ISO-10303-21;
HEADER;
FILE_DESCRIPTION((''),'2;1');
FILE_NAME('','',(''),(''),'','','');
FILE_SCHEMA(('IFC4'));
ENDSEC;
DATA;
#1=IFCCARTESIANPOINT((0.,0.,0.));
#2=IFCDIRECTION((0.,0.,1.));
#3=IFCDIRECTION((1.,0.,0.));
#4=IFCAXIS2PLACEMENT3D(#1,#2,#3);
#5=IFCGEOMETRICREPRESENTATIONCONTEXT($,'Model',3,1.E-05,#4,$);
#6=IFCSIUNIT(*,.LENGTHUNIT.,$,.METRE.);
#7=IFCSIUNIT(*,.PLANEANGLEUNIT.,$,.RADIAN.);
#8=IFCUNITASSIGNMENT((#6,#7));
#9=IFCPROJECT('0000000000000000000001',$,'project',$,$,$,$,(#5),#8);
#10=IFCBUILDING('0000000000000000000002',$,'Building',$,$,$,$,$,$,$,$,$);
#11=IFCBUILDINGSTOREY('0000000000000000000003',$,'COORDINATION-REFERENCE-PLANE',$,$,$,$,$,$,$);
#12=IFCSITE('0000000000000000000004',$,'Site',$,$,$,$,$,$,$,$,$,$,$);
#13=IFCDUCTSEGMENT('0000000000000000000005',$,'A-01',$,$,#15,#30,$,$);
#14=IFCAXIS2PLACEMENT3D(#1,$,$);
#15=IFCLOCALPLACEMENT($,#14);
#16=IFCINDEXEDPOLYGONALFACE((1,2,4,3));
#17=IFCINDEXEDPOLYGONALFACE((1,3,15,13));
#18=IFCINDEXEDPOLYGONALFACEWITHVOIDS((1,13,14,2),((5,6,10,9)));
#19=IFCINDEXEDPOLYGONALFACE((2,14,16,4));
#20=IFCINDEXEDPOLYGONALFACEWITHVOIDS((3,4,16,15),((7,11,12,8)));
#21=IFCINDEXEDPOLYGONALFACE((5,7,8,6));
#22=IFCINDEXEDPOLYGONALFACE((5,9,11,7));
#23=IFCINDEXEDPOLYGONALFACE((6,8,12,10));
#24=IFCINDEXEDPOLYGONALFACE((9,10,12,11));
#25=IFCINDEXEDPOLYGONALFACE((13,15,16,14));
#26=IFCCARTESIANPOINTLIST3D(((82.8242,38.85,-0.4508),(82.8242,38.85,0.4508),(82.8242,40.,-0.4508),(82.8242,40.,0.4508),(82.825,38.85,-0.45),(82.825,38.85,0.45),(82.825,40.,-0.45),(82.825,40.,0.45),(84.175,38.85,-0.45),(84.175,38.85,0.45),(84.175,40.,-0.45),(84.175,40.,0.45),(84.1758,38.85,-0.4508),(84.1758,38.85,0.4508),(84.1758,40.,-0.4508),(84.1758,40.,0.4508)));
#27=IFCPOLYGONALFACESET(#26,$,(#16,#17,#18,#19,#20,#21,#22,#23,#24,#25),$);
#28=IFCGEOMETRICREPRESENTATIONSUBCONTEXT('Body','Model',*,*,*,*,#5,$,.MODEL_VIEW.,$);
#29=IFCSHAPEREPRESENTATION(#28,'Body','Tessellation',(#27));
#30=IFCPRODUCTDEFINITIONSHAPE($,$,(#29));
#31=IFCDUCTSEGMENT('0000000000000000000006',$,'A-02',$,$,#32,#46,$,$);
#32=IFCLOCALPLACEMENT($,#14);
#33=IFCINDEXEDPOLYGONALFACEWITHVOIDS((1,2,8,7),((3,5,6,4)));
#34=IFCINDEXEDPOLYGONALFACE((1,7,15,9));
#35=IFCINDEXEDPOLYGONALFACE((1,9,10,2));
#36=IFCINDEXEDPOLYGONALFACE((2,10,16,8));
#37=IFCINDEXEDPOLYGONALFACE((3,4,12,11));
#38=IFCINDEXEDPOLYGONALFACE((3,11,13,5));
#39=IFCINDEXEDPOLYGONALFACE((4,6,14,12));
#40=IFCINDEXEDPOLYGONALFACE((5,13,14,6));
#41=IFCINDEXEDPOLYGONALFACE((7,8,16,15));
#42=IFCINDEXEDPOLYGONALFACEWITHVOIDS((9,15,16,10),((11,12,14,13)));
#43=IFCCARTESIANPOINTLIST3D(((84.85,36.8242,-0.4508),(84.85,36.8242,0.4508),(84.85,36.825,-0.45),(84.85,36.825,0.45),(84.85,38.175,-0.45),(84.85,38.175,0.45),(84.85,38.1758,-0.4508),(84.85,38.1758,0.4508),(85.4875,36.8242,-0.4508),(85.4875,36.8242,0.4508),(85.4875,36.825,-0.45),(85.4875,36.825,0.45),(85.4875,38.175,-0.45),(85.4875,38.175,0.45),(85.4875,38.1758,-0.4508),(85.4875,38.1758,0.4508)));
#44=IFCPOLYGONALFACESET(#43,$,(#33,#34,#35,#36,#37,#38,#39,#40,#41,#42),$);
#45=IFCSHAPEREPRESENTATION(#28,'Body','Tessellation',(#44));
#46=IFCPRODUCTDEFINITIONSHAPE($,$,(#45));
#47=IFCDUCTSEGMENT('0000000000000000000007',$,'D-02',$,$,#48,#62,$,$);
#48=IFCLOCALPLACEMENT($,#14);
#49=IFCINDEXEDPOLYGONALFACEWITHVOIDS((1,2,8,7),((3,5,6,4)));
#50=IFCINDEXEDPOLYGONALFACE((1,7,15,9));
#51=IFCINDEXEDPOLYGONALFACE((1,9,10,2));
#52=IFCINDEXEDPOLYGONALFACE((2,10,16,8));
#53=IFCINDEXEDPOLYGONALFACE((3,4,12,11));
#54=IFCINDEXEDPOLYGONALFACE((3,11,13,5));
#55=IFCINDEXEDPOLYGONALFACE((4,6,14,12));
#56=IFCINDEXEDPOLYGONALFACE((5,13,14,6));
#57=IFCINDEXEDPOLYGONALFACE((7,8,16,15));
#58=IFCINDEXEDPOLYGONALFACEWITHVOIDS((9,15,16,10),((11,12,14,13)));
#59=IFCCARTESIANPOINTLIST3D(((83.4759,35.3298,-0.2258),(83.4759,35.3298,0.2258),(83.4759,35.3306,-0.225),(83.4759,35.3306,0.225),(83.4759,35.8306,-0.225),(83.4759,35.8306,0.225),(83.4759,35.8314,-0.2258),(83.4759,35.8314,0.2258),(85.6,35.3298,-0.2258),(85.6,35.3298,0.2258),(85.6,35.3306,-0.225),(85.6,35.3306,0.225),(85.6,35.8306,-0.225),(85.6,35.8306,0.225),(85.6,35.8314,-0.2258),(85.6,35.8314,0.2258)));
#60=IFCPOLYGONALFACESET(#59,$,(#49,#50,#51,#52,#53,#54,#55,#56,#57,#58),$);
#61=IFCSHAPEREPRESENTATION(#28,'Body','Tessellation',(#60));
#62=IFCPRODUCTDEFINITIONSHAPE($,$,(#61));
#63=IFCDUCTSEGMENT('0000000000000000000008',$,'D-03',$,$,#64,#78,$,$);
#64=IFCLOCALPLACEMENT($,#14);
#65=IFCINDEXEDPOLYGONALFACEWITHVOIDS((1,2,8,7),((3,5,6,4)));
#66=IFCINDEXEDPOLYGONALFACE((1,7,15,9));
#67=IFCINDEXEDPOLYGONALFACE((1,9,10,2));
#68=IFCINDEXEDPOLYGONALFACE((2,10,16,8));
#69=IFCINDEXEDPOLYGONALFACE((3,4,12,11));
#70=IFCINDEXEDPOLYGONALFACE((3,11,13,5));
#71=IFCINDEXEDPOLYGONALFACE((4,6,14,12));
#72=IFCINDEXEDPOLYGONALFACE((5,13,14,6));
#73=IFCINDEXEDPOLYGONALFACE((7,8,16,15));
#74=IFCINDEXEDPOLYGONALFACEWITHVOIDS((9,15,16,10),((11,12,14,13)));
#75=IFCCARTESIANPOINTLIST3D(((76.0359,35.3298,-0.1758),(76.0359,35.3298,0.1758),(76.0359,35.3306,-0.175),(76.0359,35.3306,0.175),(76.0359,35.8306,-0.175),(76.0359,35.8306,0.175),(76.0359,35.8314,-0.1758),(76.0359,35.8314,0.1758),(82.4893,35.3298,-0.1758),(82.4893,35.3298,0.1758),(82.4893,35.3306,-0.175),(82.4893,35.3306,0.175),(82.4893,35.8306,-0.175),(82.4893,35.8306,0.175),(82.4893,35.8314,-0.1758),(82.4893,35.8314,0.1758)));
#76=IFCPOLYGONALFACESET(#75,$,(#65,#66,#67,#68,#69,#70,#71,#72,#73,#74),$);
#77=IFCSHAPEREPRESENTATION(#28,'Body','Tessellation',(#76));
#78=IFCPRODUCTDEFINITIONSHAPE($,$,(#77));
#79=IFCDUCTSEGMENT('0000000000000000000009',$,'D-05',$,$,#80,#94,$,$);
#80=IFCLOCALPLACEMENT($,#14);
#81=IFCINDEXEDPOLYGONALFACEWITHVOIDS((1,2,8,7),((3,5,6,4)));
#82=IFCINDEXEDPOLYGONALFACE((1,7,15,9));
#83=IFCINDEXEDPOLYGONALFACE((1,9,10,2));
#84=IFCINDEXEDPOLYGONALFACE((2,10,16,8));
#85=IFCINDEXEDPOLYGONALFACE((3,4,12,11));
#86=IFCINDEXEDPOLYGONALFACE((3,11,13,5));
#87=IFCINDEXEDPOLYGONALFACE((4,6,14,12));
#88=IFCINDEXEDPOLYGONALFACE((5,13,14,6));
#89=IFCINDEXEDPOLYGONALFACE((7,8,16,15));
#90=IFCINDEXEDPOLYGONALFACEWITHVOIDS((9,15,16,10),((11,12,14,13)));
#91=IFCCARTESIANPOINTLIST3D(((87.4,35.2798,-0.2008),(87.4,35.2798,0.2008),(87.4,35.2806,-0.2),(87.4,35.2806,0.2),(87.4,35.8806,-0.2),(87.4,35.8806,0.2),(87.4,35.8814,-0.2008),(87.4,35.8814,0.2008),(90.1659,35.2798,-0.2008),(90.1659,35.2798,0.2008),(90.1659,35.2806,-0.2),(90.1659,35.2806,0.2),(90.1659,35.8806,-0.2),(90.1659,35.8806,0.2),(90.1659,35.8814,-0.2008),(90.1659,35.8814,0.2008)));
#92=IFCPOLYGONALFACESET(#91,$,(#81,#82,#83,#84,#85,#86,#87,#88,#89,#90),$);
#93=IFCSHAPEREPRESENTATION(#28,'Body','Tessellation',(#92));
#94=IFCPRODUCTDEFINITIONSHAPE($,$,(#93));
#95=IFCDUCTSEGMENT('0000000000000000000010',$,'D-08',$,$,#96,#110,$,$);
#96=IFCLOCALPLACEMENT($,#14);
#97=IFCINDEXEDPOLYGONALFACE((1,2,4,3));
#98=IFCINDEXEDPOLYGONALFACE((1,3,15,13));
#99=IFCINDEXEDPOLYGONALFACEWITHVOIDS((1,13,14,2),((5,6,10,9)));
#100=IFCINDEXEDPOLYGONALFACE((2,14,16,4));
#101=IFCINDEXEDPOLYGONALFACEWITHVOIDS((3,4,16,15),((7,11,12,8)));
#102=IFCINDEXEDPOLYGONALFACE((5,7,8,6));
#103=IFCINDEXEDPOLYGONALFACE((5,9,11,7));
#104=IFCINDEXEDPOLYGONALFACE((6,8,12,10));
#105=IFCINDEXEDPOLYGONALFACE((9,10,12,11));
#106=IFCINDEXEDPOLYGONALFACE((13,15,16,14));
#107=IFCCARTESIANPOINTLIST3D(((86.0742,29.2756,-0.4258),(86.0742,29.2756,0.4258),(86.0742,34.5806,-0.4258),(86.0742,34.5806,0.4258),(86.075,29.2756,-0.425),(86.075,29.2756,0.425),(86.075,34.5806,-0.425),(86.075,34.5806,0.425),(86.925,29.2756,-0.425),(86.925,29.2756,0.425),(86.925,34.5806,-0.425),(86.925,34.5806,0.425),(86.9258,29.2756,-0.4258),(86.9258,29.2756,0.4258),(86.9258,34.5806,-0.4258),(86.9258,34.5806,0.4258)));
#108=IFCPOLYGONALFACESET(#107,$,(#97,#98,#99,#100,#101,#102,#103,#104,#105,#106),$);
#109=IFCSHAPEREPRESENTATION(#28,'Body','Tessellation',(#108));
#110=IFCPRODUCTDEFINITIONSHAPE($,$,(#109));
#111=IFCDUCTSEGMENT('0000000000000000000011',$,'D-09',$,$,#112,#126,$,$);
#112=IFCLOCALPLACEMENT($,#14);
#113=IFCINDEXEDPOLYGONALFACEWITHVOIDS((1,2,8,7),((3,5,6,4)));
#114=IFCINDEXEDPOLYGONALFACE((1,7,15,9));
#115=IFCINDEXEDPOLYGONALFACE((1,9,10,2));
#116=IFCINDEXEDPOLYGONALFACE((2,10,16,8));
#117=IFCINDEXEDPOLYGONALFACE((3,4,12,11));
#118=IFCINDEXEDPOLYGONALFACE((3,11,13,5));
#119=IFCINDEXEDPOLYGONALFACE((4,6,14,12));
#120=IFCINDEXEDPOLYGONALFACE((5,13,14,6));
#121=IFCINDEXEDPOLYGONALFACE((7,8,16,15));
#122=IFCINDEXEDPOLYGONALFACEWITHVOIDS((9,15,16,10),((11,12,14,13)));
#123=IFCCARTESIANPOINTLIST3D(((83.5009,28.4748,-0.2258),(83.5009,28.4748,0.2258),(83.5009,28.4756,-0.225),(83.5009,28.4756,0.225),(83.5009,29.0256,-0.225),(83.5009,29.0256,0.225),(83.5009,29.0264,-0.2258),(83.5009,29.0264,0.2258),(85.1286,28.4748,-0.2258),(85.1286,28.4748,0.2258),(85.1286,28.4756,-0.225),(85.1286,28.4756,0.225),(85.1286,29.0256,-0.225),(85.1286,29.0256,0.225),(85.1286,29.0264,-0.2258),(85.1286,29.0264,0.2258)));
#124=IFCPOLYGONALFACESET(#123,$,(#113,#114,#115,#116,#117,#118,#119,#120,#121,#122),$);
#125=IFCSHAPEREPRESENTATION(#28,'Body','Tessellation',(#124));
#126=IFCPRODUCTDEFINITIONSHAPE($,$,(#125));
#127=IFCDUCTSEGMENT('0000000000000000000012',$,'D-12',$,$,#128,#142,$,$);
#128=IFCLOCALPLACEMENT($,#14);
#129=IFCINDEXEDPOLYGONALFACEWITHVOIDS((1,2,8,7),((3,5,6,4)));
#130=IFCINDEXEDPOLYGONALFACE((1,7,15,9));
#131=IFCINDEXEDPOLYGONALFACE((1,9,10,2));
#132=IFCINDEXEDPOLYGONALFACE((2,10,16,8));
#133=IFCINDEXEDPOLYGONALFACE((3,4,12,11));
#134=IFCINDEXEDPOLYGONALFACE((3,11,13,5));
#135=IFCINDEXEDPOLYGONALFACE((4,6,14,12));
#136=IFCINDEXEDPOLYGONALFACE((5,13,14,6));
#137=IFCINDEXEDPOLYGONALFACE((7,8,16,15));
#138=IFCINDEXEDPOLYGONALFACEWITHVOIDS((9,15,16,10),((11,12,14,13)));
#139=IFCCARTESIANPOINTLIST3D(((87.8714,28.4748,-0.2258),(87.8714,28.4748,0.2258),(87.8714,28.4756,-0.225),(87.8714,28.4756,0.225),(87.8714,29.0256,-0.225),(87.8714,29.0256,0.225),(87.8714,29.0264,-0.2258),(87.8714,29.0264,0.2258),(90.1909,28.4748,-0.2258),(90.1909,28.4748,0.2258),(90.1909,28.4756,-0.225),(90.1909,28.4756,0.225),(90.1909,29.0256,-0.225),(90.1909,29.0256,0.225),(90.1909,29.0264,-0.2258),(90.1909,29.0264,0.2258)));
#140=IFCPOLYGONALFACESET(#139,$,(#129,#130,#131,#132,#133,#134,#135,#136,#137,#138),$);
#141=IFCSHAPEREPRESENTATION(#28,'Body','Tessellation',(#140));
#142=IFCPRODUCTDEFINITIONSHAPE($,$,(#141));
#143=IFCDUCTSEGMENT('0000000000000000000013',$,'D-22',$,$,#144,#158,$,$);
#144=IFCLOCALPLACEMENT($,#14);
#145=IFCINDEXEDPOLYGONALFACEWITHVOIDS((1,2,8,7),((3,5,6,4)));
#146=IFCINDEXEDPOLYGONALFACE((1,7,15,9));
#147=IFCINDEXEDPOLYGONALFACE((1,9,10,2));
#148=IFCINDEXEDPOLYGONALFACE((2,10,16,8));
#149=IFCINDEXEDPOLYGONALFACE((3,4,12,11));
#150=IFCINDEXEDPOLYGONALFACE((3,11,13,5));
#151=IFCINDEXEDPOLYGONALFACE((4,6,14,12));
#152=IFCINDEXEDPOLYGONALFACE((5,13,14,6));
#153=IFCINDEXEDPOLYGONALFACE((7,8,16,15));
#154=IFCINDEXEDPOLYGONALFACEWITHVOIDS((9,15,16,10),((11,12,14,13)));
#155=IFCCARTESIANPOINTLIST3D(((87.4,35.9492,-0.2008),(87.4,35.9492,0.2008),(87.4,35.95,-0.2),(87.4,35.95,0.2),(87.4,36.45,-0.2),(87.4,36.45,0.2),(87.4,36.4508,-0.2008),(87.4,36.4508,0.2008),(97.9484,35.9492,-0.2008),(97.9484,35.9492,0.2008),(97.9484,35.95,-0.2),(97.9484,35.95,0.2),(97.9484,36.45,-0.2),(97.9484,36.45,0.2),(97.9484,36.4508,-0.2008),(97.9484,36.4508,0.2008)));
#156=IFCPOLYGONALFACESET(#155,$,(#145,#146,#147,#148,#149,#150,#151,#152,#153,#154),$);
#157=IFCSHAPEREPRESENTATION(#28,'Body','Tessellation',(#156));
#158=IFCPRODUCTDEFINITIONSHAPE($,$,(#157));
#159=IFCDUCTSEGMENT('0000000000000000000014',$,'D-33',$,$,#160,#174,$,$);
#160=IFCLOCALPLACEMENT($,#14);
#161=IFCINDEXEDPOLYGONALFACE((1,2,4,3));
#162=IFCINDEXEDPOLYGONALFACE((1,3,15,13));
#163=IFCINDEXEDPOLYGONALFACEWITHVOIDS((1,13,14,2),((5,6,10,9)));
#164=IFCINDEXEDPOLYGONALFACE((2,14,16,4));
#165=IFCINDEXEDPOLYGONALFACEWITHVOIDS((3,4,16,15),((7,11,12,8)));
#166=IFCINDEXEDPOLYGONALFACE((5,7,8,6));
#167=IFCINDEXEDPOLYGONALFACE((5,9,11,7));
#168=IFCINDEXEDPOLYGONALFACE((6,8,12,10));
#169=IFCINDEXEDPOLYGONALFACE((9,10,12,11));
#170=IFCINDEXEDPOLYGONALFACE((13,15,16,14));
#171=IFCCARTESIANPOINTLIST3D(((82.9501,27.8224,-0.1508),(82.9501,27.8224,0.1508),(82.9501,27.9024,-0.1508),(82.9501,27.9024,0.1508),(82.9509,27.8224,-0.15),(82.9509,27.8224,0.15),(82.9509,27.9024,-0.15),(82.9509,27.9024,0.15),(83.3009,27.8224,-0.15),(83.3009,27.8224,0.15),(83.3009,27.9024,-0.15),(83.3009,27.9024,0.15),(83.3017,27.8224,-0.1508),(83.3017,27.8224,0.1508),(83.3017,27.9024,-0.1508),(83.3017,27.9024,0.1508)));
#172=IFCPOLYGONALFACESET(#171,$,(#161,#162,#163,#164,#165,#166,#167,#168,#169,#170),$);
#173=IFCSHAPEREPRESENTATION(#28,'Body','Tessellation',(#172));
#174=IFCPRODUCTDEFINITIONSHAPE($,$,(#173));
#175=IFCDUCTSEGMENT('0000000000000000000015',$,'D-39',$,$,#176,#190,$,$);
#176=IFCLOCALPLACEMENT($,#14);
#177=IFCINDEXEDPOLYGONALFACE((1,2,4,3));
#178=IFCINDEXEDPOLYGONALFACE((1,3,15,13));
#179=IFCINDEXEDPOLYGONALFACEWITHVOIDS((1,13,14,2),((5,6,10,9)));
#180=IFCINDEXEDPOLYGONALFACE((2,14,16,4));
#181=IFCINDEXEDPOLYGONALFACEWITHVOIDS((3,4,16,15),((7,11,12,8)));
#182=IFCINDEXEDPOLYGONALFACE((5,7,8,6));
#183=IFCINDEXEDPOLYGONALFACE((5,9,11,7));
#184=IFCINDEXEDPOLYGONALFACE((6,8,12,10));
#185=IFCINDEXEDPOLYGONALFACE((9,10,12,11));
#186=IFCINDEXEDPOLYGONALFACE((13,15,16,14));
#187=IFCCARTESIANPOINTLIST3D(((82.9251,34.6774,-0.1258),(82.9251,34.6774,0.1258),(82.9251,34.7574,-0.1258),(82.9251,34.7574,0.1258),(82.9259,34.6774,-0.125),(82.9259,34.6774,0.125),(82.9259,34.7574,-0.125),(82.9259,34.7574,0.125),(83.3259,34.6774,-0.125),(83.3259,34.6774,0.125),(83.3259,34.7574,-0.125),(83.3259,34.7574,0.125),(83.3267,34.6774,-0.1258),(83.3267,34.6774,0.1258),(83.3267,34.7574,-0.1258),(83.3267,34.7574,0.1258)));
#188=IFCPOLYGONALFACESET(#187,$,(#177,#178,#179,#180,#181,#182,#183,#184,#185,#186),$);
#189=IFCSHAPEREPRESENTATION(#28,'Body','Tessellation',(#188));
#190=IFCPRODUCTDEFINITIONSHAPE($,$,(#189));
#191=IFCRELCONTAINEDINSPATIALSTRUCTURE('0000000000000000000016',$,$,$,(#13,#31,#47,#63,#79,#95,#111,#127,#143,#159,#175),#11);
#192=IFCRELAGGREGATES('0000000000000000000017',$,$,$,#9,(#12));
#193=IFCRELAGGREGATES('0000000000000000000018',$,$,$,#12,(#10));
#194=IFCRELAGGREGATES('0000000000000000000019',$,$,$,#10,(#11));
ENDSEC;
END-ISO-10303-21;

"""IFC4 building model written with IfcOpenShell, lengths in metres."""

from ifc_helpers import new_model, si_unit, frame, origin, origin_with_axes, place, context, subcontext, project, spatial, hollow_rectangle, extrude, element, save


model = new_model("IFC4")

# Units and contexts
model_context = context("Model", 3, precision=1e-05, world=origin_with_axes())
body_context_1 = subcontext(model_context, "Body", "Model", "MODEL_VIEW")
ifc_project = project(units=[si_unit("LENGTHUNIT", "METRE"), si_unit("PLANEANGLEUNIT", "RADIAN")], contexts=[model_context])

# Site, building, storey
site = spatial("IfcSite", under=ifc_project, Name="Site")
building = spatial("IfcBuilding", under=site, Name="Building")
storey = spatial("IfcBuildingStorey", under=building, Name="COORDINATION-REFERENCE-PLANE")

# Duct segments
duct_segment_1_placement = place(None, frame((83.5, 38.85, 0.0), z_axis=(0.0, 1.0, 0.0), x_axis=(1.0, 0.0, 0.0)))
element("IfcDuctSegment", 1, at=duct_segment_1_placement, inside=storey, Name="A-01", context=body_context_1, shape_type="SweptSolid", body=[
    extrude(hollow_rectangle(XDim=1.3516, YDim=0.9016, WallThickness=0.0008), origin(), (0.0, 0.0, 1.0), 1.15),
])
duct_segment_2_placement = place(None, frame((84.85, 37.5, 0.0), z_axis=(1.0, 0.0, 0.0), x_axis=(0.0, 1.0, 0.0)))
element("IfcDuctSegment", 2, at=duct_segment_2_placement, inside=storey, Name="A-02", context=body_context_1, shape_type="SweptSolid", body=[
    extrude(hollow_rectangle(XDim=1.3516, YDim=0.9016, WallThickness=0.0008), origin(), (0.0, 0.0, 1.0), 0.6375),
])
duct_segment_3_placement = place(None, frame((83.4759, 35.5806, 0.0), z_axis=(1.0, 0.0, 0.0), x_axis=(0.0, 1.0, 0.0)))
element("IfcDuctSegment", 3, at=duct_segment_3_placement, inside=storey, Name="D-02", context=body_context_1, shape_type="SweptSolid", body=[
    extrude(hollow_rectangle(XDim=0.5016, YDim=0.4516, WallThickness=0.0008), origin(), (0.0, 0.0, 1.0), 2.1241),
])
duct_segment_4_placement = place(None, frame((76.0359, 35.5806, 0.0), z_axis=(1.0, 0.0, 0.0), x_axis=(0.0, 1.0, 0.0)))
element("IfcDuctSegment", 4, at=duct_segment_4_placement, inside=storey, Name="D-03", context=body_context_1, shape_type="SweptSolid", body=[
    extrude(hollow_rectangle(XDim=0.5016, YDim=0.3516, WallThickness=0.0008), origin(), (0.0, 0.0, 1.0), 6.4534),
])
duct_segment_5_placement = place(None, frame((87.4, 35.5806, 0.0), z_axis=(1.0, 0.0, 0.0), x_axis=(0.0, 1.0, 0.0)))
element("IfcDuctSegment", 5, at=duct_segment_5_placement, inside=storey, Name="D-05", context=body_context_1, shape_type="SweptSolid", body=[
    extrude(hollow_rectangle(XDim=0.6016, YDim=0.4016, WallThickness=0.0008), origin(), (0.0, 0.0, 1.0), 2.7659),
])
duct_segment_6_placement = place(None, frame((86.5, 29.2756, 0.0), z_axis=(0.0, 1.0, 0.0), x_axis=(1.0, 0.0, 0.0)))
element("IfcDuctSegment", 6, at=duct_segment_6_placement, inside=storey, Name="D-08", context=body_context_1, shape_type="SweptSolid", body=[
    extrude(hollow_rectangle(XDim=0.8516, YDim=0.8516, WallThickness=0.0008), origin(), (0.0, 0.0, 1.0), 5.305),
])
duct_segment_7_placement = place(None, frame((83.5009, 28.7506, 0.0), z_axis=(1.0, 0.0, 0.0), x_axis=(0.0, 1.0, 0.0)))
element("IfcDuctSegment", 7, at=duct_segment_7_placement, inside=storey, Name="D-09", context=body_context_1, shape_type="SweptSolid", body=[
    extrude(hollow_rectangle(XDim=0.5516, YDim=0.4516, WallThickness=0.0008), origin(), (0.0, 0.0, 1.0), 1.6277),
])
duct_segment_8_placement = place(None, frame((87.8714, 28.7506, 0.0), z_axis=(1.0, 0.0, 0.0), x_axis=(0.0, 1.0, 0.0)))
element("IfcDuctSegment", 8, at=duct_segment_8_placement, inside=storey, Name="D-12", context=body_context_1, shape_type="SweptSolid", body=[
    extrude(hollow_rectangle(XDim=0.5516, YDim=0.4516, WallThickness=0.0008), origin(), (0.0, 0.0, 1.0), 2.3195),
])
duct_segment_9_placement = place(None, frame((87.4, 36.2, 0.0), z_axis=(1.0, 0.0, 0.0), x_axis=(0.0, 1.0, 0.0)))
element("IfcDuctSegment", 9, at=duct_segment_9_placement, inside=storey, Name="D-22", context=body_context_1, shape_type="SweptSolid", body=[
    extrude(hollow_rectangle(XDim=0.5016, YDim=0.4016, WallThickness=0.0008), origin(), (0.0, 0.0, 1.0), 10.5484),
])
duct_segment_10_placement = place(None, frame((83.1259, 27.8224, 0.0), z_axis=(0.0, 1.0, 0.0), x_axis=(1.0, 0.0, 0.0)))
element("IfcDuctSegment", 10, at=duct_segment_10_placement, inside=storey, Name="D-33", context=body_context_1, shape_type="SweptSolid", body=[
    extrude(hollow_rectangle(XDim=0.3516, YDim=0.3016, WallThickness=0.0008), origin(), (0.0, 0.0, 1.0), 0.08),
])
duct_segment_11_placement = place(None, frame((83.1259, 34.6774, 0.0), z_axis=(0.0, 1.0, 0.0), x_axis=(1.0, 0.0, 0.0)))
element("IfcDuctSegment", 11, at=duct_segment_11_placement, inside=storey, Name="D-39", context=body_context_1, shape_type="SweptSolid", body=[
    extrude(hollow_rectangle(XDim=0.4016, YDim=0.2516, WallThickness=0.0008), origin(), (0.0, 0.0, 1.0), 0.08),
])

save(model, "model.ifc")
